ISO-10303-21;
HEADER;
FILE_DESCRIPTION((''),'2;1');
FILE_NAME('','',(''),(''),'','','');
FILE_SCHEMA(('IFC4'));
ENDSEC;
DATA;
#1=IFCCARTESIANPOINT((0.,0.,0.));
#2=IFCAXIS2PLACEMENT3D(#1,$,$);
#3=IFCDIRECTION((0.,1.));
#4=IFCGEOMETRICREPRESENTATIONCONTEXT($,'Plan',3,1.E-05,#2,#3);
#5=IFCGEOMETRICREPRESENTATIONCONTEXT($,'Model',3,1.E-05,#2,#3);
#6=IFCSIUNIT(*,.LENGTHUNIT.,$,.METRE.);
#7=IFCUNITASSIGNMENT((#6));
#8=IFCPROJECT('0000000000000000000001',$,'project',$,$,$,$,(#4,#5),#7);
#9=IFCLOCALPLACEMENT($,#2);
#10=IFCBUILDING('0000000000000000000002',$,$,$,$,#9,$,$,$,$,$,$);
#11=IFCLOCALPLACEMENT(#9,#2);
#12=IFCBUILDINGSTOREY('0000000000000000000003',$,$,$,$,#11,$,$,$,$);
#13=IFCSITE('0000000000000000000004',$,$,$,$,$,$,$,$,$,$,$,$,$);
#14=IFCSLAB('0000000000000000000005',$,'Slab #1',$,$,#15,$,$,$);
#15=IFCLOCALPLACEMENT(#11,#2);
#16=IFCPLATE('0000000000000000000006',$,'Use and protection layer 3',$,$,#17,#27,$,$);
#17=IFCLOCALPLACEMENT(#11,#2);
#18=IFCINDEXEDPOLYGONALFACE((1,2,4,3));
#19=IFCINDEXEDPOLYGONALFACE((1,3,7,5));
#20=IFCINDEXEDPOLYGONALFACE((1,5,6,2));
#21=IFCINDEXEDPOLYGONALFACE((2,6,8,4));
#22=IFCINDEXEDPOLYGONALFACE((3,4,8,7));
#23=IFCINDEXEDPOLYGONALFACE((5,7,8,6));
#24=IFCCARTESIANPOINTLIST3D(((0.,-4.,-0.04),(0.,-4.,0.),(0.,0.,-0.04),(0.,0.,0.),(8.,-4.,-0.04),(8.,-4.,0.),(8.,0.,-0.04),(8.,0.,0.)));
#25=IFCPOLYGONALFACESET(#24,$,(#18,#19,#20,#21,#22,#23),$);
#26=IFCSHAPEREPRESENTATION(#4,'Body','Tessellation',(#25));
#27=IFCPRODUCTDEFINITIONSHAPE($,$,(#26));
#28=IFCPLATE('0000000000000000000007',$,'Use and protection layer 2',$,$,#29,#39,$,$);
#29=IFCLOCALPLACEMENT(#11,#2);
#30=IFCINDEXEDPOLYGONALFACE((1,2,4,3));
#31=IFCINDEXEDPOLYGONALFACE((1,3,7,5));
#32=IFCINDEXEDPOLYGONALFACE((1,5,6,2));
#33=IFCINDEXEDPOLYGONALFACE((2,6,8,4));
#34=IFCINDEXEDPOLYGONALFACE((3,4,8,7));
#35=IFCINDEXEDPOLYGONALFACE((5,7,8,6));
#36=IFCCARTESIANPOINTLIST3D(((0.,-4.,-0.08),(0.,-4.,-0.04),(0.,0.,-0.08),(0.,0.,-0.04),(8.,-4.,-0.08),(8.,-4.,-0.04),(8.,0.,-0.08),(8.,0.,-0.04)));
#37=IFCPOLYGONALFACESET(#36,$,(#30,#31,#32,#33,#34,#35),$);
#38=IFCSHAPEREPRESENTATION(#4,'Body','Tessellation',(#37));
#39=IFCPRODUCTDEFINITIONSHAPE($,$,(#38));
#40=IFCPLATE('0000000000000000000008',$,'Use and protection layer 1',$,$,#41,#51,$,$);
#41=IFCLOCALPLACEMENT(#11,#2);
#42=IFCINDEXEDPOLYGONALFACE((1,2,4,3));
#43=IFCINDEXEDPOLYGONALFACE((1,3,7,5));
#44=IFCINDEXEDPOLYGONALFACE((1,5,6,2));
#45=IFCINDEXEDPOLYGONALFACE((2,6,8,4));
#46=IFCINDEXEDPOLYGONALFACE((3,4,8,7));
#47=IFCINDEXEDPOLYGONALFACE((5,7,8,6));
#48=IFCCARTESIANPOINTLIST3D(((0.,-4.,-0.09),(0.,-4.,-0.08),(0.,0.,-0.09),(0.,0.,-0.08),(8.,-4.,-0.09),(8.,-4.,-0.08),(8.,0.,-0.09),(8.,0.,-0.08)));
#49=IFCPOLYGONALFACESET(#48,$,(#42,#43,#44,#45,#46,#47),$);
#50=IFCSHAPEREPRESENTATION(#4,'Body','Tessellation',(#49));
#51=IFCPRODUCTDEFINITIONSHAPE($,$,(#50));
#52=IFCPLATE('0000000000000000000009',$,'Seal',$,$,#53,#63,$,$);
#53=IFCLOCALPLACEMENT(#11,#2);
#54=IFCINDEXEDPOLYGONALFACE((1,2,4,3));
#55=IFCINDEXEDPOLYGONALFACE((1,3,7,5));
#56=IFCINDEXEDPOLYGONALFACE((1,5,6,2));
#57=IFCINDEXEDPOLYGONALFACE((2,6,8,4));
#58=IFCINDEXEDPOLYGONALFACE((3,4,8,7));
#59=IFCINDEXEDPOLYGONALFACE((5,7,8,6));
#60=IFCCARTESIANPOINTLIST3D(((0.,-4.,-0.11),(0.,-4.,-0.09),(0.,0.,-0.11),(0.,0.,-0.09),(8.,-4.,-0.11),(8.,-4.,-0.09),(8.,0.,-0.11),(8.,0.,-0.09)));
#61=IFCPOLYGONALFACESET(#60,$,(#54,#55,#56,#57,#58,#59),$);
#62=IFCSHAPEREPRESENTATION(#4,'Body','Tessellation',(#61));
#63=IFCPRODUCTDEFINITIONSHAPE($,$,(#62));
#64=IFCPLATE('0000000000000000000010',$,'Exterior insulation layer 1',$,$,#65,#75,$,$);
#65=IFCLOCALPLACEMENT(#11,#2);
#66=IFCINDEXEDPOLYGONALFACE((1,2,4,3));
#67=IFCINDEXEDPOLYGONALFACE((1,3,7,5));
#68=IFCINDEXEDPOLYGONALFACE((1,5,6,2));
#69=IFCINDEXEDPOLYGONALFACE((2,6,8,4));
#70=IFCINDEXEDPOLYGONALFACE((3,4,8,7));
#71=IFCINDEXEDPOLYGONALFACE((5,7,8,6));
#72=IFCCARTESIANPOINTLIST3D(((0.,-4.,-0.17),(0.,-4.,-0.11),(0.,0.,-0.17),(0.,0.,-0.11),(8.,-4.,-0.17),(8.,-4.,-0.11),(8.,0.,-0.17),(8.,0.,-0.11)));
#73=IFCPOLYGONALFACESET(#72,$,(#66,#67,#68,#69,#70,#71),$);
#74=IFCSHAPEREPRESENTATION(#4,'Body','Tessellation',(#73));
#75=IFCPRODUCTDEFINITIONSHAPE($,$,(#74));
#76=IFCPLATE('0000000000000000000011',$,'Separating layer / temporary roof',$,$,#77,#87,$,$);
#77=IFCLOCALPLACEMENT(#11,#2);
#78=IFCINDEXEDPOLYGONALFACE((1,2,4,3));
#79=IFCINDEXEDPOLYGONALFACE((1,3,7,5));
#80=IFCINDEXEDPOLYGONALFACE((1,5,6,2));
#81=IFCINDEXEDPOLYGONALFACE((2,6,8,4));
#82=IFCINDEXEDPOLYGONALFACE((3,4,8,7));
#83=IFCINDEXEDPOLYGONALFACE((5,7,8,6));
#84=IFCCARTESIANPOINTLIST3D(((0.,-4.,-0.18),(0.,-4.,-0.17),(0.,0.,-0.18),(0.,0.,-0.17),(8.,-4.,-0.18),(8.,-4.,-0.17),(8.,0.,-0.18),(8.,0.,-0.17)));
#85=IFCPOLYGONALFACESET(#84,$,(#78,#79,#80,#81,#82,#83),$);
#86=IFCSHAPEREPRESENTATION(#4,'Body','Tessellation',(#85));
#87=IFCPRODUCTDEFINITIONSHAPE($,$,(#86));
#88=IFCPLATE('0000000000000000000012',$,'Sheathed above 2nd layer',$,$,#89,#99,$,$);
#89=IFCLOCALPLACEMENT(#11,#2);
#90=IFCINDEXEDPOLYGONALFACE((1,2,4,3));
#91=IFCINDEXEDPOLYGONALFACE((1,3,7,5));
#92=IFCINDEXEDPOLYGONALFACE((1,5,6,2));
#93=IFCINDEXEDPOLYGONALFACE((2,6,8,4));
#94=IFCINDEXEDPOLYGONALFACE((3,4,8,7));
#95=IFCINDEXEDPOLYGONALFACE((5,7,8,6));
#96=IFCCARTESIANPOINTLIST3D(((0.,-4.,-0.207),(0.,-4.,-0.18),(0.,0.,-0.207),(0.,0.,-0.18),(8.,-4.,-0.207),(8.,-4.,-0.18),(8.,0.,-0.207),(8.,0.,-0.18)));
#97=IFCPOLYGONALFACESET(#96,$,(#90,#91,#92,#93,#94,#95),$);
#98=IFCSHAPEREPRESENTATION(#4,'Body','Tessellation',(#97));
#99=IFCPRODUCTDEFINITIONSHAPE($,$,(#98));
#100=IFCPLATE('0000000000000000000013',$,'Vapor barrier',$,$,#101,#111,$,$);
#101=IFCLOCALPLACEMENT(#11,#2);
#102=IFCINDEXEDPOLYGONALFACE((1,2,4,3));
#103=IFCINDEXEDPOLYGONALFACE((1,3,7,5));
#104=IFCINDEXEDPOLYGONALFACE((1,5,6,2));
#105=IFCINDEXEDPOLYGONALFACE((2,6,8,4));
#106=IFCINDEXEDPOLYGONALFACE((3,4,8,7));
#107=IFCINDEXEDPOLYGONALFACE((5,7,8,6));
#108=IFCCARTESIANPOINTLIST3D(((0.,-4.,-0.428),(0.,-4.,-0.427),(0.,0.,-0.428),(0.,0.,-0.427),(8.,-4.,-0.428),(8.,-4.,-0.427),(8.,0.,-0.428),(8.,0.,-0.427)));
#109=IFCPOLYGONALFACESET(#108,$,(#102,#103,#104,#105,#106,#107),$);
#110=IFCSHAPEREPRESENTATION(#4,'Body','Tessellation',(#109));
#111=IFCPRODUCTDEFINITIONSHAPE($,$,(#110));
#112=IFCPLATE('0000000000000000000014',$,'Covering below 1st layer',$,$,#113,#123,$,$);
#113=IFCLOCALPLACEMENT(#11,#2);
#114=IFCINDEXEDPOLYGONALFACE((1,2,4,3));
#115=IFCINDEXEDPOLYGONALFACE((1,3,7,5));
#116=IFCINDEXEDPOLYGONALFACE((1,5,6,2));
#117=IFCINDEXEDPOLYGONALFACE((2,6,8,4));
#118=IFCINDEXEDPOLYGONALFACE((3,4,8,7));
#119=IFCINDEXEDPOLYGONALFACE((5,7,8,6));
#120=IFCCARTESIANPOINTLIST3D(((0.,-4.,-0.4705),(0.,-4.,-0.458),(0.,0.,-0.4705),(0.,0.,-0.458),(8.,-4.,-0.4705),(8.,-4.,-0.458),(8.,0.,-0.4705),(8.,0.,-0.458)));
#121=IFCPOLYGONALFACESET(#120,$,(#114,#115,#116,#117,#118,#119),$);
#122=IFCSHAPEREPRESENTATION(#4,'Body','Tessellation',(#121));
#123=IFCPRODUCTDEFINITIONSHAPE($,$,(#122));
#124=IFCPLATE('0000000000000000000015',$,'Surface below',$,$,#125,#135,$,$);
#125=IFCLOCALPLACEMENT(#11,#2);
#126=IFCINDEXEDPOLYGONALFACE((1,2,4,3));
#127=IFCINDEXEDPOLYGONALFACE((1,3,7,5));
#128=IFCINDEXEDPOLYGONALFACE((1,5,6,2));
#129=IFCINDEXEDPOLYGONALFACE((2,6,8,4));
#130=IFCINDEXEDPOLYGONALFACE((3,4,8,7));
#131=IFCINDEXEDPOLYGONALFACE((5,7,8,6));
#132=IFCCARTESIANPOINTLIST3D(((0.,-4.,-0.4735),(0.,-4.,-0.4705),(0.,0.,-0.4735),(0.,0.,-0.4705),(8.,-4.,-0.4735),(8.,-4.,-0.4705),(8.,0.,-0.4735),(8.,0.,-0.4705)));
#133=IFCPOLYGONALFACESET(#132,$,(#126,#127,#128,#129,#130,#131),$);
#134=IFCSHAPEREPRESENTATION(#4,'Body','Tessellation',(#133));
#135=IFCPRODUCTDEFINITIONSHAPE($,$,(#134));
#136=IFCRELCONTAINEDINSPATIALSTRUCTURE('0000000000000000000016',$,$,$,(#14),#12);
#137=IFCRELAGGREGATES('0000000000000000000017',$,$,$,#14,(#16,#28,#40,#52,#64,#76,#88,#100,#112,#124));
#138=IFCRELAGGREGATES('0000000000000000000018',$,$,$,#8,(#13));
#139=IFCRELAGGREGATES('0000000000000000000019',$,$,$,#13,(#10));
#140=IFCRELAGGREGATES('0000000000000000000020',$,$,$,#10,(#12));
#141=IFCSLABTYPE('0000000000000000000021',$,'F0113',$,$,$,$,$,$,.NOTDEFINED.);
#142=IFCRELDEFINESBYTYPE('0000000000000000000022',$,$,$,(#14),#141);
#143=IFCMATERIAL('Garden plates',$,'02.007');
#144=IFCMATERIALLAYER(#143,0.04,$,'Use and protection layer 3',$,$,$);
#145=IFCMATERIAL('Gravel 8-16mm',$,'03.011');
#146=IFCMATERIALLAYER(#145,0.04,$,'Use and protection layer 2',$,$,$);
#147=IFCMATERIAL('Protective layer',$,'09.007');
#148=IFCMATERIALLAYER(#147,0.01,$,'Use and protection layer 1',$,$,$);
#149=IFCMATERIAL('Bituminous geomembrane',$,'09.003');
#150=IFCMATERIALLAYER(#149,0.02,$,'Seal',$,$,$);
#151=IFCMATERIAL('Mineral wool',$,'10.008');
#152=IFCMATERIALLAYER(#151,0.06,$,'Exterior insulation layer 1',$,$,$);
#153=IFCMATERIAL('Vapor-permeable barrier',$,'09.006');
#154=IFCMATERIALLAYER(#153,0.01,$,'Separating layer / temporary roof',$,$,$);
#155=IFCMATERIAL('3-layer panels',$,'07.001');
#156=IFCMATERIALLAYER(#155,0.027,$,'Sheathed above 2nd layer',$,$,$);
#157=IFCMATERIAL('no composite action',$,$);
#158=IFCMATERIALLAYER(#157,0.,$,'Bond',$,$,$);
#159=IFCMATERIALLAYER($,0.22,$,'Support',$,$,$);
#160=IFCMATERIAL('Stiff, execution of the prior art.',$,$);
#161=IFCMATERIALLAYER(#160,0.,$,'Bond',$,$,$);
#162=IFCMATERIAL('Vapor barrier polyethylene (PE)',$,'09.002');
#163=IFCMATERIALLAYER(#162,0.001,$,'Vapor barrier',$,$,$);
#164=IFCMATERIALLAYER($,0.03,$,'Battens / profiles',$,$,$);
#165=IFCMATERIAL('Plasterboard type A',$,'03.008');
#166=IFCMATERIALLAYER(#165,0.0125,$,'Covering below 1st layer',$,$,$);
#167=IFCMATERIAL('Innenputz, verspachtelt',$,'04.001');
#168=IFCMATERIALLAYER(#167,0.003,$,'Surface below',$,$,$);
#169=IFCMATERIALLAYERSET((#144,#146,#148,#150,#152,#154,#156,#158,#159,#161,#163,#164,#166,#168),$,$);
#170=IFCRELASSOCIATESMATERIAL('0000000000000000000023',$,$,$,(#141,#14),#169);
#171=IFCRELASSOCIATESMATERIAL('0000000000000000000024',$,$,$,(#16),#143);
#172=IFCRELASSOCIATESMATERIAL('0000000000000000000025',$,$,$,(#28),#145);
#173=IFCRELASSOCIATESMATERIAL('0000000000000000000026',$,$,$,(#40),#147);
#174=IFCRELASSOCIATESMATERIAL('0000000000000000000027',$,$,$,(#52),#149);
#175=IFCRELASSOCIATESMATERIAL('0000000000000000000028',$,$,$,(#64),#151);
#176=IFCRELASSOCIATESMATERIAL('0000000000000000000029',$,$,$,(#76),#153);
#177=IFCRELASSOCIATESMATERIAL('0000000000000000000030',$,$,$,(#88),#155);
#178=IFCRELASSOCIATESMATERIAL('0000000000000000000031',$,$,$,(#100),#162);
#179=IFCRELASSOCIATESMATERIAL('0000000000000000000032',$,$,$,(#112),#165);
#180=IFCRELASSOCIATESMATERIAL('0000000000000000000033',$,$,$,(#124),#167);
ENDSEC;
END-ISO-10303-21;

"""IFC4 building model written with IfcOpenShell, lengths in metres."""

from ifc_helpers import new_model, si_unit, direction, frame, frame_2d, origin, origin_with_axes, place, context, project, spatial, rectangle, extrude, material, layer, layer_set, type_object, element, aggregate, save


model = new_model("IFC4")

# Units and contexts
plan_context = context("Plan", 3, precision=1e-05, world=origin(), true_north=direction((0.0, 1.0)))
model_context = context("Model", 3, precision=1e-05, world=origin(), true_north=direction((0.0, 1.0)))
ifc_project = project(units=[si_unit("LENGTHUNIT", "METRE")], contexts=[plan_context, model_context])

# Site, building, storey
site = spatial("IfcSite", under=ifc_project)
building_placement = place(None, origin())
building = spatial("IfcBuilding", under=site, at=building_placement)
storey_placement = place(building_placement, origin())
storey = spatial("IfcBuildingStorey", under=building, at=storey_placement)

# Slab, plates
ifc_material_1 = material(Name="Garden plates", Category="02.007")
ifc_layer_1 = layer(ifc_material_1, 0.04, Name="Use and protection layer 3")
ifc_material_2 = material(Name="Gravel 8-16mm", Category="03.011")
ifc_layer_2 = layer(ifc_material_2, 0.04, Name="Use and protection layer 2")
ifc_material_3 = material(Name="Protective layer", Category="09.007")
ifc_layer_3 = layer(ifc_material_3, 0.01, Name="Use and protection layer 1")
ifc_material_4 = material(Name="Bituminous geomembrane", Category="09.003")
ifc_layer_4 = layer(ifc_material_4, 0.02, Name="Seal")
ifc_material_5 = material(Name="Mineral wool", Category="10.008")
ifc_layer_5 = layer(ifc_material_5, 0.06, Name="Exterior insulation layer 1")
ifc_material_6 = material(Name="Vapor-permeable barrier", Category="09.006")
ifc_layer_6 = layer(ifc_material_6, 0.01, Name="Separating layer / temporary roof")
ifc_material_7 = material(Name="3-layer panels", Category="07.001")
ifc_layer_7 = layer(ifc_material_7, 0.027, Name="Sheathed above 2nd layer")
ifc_material_8 = material(Name="no composite action")
ifc_layer_8 = layer(ifc_material_8, 0.0, Name="Bond")
ifc_layer_9 = layer(None, 0.22, Name="Support")
ifc_material_9 = material(Name="Stiff, execution of the prior art.")
ifc_layer_10 = layer(ifc_material_9, 0.0, Name="Bond")
ifc_material_10 = material(Name="Vapor barrier polyethylene (PE)", Category="09.002")
ifc_layer_11 = layer(ifc_material_10, 0.001, Name="Vapor barrier")
ifc_layer_12 = layer(None, 0.03, Name="Battens / profiles")
ifc_material_11 = material(Name="Plasterboard type A", Category="03.008")
ifc_layer_13 = layer(ifc_material_11, 0.0125, Name="Covering below 1st layer")
ifc_material_12 = material(Name="Innenputz, verspachtelt", Category="04.001")
ifc_layer_14 = layer(ifc_material_12, 0.003, Name="Surface below")
ifc_layer_set = layer_set([ifc_layer_1, ifc_layer_2, ifc_layer_3, ifc_layer_4, ifc_layer_5, ifc_layer_6, ifc_layer_7, ifc_layer_8, ifc_layer_9, ifc_layer_10, ifc_layer_11, ifc_layer_12, ifc_layer_13, ifc_layer_14])
slab_type = type_object("IfcSlabType", Name="F0113", PredefinedType="NOTDEFINED", material=ifc_layer_set)
slab_placement = place(None, frame((0.0, 0.0, 0.0), z_axis=(0.0, 0.0, -1.0), x_axis=(1.0, 0.0, 0.0)))
slab = element("IfcSlab", 1, at=slab_placement, inside=storey, type_object=slab_type, material=ifc_layer_set, Name="Slab #1")
plate_1_placement = place(slab_placement, origin())
plate_1 = element("IfcPlate", 2, at=plate_1_placement, material=ifc_material_1, Name="Use and protection layer 3", context=plan_context, shape_type="SweptSolid", body=[
    extrude(rectangle(XDim=8.0, YDim=4.0, at=frame_2d((4.0, 2.0), x_axis=(1.0, 0.0))), origin_with_axes(), (0.0, 0.0, 1.0), 0.04),
])
plate_2_placement = place(slab_placement, origin())
plate_2 = element("IfcPlate", 3, at=plate_2_placement, material=ifc_material_2, Name="Use and protection layer 2", context=plan_context, shape_type="SweptSolid", body=[
    extrude(rectangle(XDim=8.0, YDim=4.0, at=frame_2d((4.0, 2.0), x_axis=(1.0, 0.0))), frame((0.0, 0.0, 0.04), z_axis=(0.0, 0.0, 1.0), x_axis=(1.0, 0.0, 0.0)), (0.0, 0.0, 1.0), 0.04),
])
plate_3_placement = place(slab_placement, origin())
plate_3 = element("IfcPlate", 4, at=plate_3_placement, material=ifc_material_3, Name="Use and protection layer 1", context=plan_context, shape_type="SweptSolid", body=[
    extrude(rectangle(XDim=8.0, YDim=4.0, at=frame_2d((4.0, 2.0), x_axis=(1.0, 0.0))), frame((0.0, 0.0, 0.08), z_axis=(0.0, 0.0, 1.0), x_axis=(1.0, 0.0, 0.0)), (0.0, 0.0, 1.0), 0.01),
])
plate_4_placement = place(slab_placement, origin())
plate_4 = element("IfcPlate", 5, at=plate_4_placement, material=ifc_material_4, Name="Seal", context=plan_context, shape_type="SweptSolid", body=[
    extrude(rectangle(XDim=8.0, YDim=4.0, at=frame_2d((4.0, 2.0), x_axis=(1.0, 0.0))), frame((0.0, 0.0, 0.09), z_axis=(0.0, 0.0, 1.0), x_axis=(1.0, 0.0, 0.0)), (0.0, 0.0, 1.0), 0.02),
])
plate_5_placement = place(slab_placement, origin())
plate_5 = element("IfcPlate", 6, at=plate_5_placement, material=ifc_material_5, Name="Exterior insulation layer 1", context=plan_context, shape_type="SweptSolid", body=[
    extrude(rectangle(XDim=8.0, YDim=4.0, at=frame_2d((4.0, 2.0), x_axis=(1.0, 0.0))), frame((0.0, 0.0, 0.11), z_axis=(0.0, 0.0, 1.0), x_axis=(1.0, 0.0, 0.0)), (0.0, 0.0, 1.0), 0.06),
])
plate_6_placement = place(slab_placement, origin())
plate_6 = element("IfcPlate", 7, at=plate_6_placement, material=ifc_material_6, Name="Separating layer / temporary roof", context=plan_context, shape_type="SweptSolid", body=[
    extrude(rectangle(XDim=8.0, YDim=4.0, at=frame_2d((4.0, 2.0), x_axis=(1.0, 0.0))), frame((0.0, 0.0, 0.17), z_axis=(0.0, 0.0, 1.0), x_axis=(1.0, 0.0, 0.0)), (0.0, 0.0, 1.0), 0.01),
])
plate_7_placement = place(slab_placement, origin())
plate_7 = element("IfcPlate", 8, at=plate_7_placement, material=ifc_material_7, Name="Sheathed above 2nd layer", context=plan_context, shape_type="SweptSolid", body=[
    extrude(rectangle(XDim=8.0, YDim=4.0, at=frame_2d((4.0, 2.0), x_axis=(1.0, 0.0))), frame((0.0, 0.0, 0.18), z_axis=(0.0, 0.0, 1.0), x_axis=(1.0, 0.0, 0.0)), (0.0, 0.0, 1.0), 0.027),
])
plate_8_placement = place(slab_placement, origin())
plate_8 = element("IfcPlate", 9, at=plate_8_placement, material=ifc_material_10, Name="Vapor barrier", context=plan_context, shape_type="SweptSolid", body=[
    extrude(rectangle(XDim=8.0, YDim=4.0, at=frame_2d((4.0, 2.0), x_axis=(1.0, 0.0))), frame((0.0, 0.0, 0.427), z_axis=(0.0, 0.0, 1.0), x_axis=(1.0, 0.0, 0.0)), (0.0, 0.0, 1.0), 0.001),
])
plate_9_placement = place(slab_placement, origin())
plate_9 = element("IfcPlate", 10, at=plate_9_placement, material=ifc_material_11, Name="Covering below 1st layer", context=plan_context, shape_type="SweptSolid", body=[
    extrude(rectangle(XDim=8.0, YDim=4.0, at=frame_2d((4.0, 2.0), x_axis=(1.0, 0.0))), frame((0.0, 0.0, 0.458), z_axis=(0.0, 0.0, 1.0), x_axis=(1.0, 0.0, 0.0)), (0.0, 0.0, 1.0), 0.0125),
])
plate_10_placement = place(slab_placement, origin())
plate_10 = element("IfcPlate", 11, at=plate_10_placement, material=ifc_material_12, Name="Surface below", context=plan_context, shape_type="SweptSolid", body=[
    extrude(rectangle(XDim=8.0, YDim=4.0, at=frame_2d((4.0, 2.0), x_axis=(1.0, 0.0))), frame((0.0, 0.0, 0.4705), z_axis=(0.0, 0.0, 1.0), x_axis=(1.0, 0.0, 0.0)), (0.0, 0.0, 1.0), 0.003),
])
aggregate(slab, [plate_1, plate_2, plate_3, plate_4, plate_5, plate_6, plate_7, plate_8, plate_9, plate_10])

save(model, "model.ifc")
